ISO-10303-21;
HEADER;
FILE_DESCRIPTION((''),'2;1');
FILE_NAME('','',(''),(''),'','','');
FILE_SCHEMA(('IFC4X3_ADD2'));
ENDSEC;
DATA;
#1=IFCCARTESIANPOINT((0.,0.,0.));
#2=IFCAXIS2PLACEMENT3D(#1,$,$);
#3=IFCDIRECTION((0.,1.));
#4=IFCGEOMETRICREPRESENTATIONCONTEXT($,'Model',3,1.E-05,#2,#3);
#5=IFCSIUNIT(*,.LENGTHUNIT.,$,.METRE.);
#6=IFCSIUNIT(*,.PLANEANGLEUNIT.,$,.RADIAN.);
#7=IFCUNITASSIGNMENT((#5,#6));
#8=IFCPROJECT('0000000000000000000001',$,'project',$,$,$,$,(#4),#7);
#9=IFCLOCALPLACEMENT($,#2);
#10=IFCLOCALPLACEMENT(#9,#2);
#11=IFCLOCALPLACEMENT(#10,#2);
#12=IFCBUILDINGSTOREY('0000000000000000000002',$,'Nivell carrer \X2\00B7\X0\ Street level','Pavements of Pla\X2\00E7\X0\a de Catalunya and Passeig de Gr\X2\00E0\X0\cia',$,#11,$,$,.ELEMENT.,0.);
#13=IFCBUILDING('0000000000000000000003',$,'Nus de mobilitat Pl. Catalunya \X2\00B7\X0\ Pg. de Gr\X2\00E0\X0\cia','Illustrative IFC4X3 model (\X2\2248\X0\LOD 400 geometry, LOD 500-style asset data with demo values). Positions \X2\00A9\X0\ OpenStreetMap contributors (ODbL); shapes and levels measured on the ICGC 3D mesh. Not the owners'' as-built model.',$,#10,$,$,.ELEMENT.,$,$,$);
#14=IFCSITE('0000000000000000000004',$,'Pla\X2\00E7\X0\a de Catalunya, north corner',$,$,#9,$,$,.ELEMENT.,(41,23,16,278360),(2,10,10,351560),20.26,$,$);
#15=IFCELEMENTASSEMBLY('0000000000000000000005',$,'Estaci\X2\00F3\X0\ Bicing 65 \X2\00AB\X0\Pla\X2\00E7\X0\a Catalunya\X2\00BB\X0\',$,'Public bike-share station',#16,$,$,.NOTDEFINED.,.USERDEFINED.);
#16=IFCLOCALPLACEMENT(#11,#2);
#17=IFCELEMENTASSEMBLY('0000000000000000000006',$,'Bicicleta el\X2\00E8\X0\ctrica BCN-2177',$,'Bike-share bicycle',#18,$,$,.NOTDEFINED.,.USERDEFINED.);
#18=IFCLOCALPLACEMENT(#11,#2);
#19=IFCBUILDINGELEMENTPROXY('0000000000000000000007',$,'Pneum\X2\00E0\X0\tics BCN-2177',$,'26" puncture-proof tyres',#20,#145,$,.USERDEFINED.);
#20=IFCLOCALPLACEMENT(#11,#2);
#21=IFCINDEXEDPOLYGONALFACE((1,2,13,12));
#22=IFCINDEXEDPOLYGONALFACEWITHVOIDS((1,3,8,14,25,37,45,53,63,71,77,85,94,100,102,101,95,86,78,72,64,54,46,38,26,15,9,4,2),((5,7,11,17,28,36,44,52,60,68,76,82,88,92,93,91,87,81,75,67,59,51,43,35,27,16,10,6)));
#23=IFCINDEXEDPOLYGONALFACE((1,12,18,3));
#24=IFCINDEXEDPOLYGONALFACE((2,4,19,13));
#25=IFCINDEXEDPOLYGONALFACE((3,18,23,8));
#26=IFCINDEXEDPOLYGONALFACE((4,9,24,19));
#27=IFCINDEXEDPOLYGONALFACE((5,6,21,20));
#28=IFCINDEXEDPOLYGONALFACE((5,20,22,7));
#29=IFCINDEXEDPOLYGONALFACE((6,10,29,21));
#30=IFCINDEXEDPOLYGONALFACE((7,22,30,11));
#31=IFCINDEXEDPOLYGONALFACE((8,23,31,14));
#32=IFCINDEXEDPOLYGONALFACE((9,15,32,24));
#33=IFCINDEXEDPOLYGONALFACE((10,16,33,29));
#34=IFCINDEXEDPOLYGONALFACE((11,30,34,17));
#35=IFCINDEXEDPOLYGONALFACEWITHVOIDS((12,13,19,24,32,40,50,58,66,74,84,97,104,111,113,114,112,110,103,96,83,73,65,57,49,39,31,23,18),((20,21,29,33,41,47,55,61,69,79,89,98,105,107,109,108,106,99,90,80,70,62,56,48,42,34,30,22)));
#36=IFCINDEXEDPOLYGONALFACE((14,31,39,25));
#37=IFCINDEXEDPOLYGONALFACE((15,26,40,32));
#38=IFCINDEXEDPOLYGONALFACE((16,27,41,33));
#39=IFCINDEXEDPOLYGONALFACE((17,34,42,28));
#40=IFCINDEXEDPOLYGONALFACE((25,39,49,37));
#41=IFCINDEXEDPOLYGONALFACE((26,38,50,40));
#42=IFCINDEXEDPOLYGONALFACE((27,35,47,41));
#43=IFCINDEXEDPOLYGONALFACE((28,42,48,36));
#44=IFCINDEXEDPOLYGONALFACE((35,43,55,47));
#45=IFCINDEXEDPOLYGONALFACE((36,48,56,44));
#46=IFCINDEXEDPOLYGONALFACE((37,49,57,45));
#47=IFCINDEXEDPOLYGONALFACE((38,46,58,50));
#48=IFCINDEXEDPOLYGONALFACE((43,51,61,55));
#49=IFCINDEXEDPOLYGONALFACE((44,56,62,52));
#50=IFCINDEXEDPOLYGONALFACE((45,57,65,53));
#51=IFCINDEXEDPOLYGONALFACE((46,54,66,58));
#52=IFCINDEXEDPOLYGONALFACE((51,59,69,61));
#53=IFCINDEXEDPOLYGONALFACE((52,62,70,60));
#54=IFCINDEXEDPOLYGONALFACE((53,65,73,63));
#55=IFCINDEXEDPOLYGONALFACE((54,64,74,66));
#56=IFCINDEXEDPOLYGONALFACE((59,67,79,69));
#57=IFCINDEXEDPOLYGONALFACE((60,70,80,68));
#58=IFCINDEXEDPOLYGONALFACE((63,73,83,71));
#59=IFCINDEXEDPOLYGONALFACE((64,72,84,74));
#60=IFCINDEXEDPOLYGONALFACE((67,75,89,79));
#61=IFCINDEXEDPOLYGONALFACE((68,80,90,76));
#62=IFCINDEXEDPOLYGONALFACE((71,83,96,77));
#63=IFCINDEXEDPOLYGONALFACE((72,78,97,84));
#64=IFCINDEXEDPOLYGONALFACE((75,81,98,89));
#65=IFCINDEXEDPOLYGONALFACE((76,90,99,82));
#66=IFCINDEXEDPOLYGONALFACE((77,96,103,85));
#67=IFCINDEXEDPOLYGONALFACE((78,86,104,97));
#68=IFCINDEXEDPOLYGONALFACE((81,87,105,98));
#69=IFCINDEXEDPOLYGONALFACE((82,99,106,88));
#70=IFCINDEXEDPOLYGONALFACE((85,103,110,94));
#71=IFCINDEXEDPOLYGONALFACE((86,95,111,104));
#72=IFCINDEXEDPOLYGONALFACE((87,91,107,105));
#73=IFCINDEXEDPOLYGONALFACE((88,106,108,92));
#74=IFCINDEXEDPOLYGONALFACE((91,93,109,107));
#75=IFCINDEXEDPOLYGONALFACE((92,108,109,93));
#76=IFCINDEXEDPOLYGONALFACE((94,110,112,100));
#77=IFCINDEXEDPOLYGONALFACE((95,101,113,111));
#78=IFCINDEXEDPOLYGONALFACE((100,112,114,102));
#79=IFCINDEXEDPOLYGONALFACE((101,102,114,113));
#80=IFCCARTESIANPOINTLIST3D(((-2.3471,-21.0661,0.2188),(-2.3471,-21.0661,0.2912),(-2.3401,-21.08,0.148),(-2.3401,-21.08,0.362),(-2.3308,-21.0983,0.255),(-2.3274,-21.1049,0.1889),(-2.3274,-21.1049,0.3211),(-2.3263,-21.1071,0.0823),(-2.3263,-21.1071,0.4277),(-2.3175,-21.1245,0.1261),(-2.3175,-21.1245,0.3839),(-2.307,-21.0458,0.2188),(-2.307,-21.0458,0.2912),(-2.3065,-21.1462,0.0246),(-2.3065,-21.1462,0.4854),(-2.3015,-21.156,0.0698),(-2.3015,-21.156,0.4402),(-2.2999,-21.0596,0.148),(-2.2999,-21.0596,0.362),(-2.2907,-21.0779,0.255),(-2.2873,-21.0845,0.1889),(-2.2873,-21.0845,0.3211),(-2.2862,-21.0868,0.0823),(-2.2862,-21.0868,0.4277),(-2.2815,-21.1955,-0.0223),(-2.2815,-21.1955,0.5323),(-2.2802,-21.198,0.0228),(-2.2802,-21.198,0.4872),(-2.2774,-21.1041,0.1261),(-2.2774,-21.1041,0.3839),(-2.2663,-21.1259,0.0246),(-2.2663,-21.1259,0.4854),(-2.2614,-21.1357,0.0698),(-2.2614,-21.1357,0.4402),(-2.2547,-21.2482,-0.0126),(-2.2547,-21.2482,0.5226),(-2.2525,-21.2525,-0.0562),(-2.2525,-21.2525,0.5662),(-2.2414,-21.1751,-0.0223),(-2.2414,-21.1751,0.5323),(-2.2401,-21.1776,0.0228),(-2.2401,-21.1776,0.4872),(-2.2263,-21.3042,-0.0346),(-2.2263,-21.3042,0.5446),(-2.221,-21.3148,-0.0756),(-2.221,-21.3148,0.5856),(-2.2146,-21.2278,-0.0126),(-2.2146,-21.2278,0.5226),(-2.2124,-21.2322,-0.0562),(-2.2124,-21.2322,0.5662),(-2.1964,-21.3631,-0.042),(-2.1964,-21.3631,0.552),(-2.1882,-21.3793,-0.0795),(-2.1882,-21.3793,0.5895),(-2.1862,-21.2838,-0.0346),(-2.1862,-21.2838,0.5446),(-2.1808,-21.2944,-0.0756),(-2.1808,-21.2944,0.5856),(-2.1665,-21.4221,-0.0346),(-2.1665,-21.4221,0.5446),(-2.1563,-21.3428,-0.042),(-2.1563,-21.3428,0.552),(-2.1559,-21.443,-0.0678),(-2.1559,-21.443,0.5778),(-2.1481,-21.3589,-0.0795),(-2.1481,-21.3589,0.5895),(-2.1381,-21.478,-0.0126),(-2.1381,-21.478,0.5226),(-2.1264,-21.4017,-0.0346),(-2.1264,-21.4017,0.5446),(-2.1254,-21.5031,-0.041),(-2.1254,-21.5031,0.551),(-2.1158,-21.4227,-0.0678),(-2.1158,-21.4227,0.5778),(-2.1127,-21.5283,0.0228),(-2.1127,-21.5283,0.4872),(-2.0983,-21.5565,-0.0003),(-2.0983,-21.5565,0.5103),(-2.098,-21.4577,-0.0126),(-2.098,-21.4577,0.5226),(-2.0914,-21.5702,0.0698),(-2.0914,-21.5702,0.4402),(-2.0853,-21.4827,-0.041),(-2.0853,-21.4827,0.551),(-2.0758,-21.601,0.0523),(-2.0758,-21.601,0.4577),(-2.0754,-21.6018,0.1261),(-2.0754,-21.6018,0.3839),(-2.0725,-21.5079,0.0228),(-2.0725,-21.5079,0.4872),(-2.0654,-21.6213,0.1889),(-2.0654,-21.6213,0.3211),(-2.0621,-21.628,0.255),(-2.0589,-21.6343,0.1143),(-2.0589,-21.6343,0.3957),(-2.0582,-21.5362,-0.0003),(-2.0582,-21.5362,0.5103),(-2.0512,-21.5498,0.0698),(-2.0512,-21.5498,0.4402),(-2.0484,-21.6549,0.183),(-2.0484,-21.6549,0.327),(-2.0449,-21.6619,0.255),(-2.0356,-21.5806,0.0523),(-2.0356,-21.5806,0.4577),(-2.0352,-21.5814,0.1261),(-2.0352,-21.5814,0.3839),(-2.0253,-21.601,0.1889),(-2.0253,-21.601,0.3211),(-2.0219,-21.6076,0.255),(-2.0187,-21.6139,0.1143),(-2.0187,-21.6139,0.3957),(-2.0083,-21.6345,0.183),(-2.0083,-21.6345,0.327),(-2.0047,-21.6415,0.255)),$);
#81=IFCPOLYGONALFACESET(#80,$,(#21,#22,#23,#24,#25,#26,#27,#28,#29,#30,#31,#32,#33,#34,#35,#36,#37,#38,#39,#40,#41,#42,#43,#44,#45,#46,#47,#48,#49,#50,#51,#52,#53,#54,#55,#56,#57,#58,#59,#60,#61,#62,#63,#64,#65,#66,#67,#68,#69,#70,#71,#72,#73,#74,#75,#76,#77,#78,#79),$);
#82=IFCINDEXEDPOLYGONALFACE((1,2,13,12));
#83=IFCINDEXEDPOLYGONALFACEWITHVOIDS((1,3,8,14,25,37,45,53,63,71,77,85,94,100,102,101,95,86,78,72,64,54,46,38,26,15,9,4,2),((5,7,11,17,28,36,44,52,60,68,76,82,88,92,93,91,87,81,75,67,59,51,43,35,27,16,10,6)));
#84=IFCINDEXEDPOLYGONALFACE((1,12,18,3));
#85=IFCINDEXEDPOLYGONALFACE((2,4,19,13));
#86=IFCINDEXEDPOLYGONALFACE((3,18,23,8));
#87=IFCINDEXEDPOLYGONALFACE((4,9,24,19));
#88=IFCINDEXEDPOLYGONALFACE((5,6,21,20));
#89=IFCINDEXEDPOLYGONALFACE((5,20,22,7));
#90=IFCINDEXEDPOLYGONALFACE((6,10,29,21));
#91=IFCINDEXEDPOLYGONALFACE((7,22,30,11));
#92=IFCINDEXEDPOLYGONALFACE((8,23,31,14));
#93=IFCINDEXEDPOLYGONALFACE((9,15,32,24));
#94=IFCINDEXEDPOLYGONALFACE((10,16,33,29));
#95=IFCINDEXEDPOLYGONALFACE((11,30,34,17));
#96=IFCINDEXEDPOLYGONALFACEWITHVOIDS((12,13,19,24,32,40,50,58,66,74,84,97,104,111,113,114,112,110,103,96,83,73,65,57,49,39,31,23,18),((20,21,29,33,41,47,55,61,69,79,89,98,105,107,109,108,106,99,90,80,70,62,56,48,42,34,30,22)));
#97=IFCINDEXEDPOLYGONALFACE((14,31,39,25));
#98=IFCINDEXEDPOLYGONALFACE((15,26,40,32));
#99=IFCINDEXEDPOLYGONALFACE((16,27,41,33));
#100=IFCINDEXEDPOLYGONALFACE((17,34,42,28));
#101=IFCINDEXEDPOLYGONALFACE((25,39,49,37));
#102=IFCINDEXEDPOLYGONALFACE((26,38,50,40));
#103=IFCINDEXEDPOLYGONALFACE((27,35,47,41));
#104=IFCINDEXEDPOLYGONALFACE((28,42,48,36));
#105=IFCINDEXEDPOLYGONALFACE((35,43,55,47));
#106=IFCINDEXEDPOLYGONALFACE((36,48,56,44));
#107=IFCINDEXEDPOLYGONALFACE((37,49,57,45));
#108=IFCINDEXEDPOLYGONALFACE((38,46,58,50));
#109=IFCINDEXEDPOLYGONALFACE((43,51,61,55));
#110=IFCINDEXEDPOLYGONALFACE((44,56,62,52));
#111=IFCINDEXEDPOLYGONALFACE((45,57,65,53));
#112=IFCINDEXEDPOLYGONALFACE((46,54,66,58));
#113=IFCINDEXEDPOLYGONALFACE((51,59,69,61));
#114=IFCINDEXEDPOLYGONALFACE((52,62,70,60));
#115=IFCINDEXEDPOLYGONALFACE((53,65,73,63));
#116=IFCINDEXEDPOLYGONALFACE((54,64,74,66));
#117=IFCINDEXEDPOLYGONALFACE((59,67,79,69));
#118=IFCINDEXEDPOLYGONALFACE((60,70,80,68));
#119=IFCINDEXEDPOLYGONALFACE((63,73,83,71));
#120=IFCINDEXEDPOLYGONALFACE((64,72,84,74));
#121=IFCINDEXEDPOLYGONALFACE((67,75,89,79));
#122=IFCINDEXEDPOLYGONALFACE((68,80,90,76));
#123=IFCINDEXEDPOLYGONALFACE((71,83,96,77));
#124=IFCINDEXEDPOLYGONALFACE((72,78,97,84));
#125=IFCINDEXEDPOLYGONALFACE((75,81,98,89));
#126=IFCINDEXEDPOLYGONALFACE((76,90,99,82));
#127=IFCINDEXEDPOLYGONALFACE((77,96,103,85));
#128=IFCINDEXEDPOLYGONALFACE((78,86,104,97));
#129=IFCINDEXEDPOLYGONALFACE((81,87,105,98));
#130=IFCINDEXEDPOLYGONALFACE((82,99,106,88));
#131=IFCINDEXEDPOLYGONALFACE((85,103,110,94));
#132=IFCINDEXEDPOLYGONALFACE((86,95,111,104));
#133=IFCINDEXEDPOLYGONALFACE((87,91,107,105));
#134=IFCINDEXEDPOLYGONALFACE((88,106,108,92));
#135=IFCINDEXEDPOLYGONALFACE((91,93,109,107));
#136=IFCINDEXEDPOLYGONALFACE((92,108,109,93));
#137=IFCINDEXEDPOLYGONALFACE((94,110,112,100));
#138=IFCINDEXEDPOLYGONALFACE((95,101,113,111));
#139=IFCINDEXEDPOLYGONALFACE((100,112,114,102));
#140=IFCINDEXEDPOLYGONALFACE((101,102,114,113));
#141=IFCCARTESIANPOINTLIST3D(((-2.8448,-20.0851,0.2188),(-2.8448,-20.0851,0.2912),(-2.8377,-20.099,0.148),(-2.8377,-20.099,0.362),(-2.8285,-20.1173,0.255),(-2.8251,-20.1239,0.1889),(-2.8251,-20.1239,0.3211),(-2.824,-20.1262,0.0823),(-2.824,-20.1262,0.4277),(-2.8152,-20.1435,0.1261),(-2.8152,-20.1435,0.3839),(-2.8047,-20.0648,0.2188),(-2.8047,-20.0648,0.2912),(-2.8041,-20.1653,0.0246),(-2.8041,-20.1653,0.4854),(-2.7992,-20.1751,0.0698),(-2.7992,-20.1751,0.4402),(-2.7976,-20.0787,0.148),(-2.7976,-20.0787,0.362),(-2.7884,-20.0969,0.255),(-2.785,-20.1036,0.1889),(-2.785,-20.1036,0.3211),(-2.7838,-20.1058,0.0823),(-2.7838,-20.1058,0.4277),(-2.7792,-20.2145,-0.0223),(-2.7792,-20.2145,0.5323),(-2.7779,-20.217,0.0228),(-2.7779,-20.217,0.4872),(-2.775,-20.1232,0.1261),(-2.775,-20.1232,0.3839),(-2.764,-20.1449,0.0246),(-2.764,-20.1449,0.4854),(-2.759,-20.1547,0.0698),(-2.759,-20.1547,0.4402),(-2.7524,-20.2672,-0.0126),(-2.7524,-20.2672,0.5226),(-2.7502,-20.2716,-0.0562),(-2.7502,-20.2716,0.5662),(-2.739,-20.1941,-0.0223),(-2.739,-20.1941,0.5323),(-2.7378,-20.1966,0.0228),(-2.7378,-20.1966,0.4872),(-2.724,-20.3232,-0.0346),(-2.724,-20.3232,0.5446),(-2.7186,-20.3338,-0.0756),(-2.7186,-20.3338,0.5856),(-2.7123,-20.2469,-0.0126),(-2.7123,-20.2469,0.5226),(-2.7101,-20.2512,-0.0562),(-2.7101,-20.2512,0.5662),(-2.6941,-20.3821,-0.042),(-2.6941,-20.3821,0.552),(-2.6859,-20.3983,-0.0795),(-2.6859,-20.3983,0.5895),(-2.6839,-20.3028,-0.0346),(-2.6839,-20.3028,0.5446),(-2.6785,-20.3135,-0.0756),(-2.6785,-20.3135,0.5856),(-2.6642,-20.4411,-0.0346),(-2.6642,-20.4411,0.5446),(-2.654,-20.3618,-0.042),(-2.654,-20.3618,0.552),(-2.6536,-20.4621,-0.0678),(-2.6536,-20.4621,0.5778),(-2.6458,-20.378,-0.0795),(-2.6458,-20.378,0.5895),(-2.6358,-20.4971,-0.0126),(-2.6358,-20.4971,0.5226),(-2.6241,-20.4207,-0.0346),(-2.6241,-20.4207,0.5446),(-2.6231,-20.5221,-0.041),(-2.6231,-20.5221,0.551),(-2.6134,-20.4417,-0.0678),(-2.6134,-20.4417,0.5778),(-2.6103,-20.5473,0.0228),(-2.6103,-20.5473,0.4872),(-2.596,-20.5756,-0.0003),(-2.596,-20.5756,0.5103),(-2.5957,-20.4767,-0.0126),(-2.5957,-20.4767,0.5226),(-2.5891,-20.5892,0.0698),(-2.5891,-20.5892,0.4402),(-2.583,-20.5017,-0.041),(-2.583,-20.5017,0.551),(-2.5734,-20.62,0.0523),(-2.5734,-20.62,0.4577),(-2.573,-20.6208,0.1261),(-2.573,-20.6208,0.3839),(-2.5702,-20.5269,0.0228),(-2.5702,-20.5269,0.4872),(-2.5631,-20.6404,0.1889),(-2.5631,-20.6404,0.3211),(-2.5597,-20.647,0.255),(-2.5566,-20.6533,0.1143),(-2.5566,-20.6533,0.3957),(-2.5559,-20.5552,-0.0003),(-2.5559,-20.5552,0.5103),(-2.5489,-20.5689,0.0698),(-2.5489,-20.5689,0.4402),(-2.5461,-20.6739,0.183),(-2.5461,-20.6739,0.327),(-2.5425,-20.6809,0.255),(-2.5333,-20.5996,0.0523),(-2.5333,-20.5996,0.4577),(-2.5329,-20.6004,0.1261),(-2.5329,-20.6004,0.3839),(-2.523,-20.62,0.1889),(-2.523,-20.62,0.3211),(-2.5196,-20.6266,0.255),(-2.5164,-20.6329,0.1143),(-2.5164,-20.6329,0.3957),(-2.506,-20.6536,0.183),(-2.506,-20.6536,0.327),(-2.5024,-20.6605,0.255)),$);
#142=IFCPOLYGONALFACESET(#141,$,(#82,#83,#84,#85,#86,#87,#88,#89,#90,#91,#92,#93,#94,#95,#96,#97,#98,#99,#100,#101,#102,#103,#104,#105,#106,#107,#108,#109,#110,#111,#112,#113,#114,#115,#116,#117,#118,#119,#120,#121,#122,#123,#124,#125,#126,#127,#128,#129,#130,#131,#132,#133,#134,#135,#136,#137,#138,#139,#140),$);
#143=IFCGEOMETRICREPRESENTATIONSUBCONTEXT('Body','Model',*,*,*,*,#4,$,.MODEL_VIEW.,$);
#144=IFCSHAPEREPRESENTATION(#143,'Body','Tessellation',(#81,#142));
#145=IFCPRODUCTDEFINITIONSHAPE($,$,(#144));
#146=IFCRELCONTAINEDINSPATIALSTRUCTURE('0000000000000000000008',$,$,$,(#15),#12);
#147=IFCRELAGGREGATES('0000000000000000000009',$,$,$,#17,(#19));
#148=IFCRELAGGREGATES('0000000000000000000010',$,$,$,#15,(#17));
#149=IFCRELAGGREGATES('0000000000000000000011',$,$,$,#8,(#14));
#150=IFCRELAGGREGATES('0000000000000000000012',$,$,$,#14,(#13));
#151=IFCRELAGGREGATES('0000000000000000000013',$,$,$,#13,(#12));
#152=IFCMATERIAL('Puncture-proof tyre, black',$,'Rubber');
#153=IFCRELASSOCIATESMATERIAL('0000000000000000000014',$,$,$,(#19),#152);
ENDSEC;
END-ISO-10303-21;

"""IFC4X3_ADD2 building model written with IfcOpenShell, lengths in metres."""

from ifc_helpers import new_model, si_unit, direction, frame, origin, origin_2d_with_axis, place, context, subcontext, project, spatial, hollow_circle, extrude, material, element, aggregate, save


model = new_model("IFC4X3_ADD2")

# Units and contexts
model_context = context("Model", 3, precision=1e-05, world=origin(), true_north=direction((0.0, 1.0)))
body_context = subcontext(model_context, "Body", "Model", "MODEL_VIEW")
ifc_project = project(units=[si_unit("LENGTHUNIT", "METRE"), si_unit("PLANEANGLEUNIT", "RADIAN")], contexts=[model_context])

# Site, building, storey
site_placement = place(None, origin())
site = spatial("IfcSite", under=ifc_project, at=site_placement, Name="Plaça de Catalunya, north corner", CompositionType="ELEMENT", RefLatitude=(41, 23, 16, 278360), RefLongitude=(2, 10, 10, 351560), RefElevation=20.26)
building_placement = place(site_placement, origin())
building = spatial("IfcBuilding", under=site, at=building_placement, Name="Nus de mobilitat Pl. Catalunya · Pg. de Gràcia", Description="Illustrative IFC4X3 model (≈LOD 400 geometry, LOD 500-style asset data with demo values). Positions © OpenStreetMap contributors (ODbL); shapes and levels measured on the ICGC 3D mesh. Not the owners' as-built model.", CompositionType="ELEMENT")
storey_placement = place(building_placement, origin())
storey = spatial("IfcBuildingStorey", under=building, at=storey_placement, Name="Nivell carrer · Street level", Description="Pavements of Plaça de Catalunya and Passeig de Gràcia", CompositionType="ELEMENT", Elevation=0.0)

# Element assemblies, building element proxy
assembly_1_placement = place(building_placement, origin())
assembly_1 = element("IfcElementAssembly", 1, at=assembly_1_placement, inside=storey, Name="Estació Bicing 65 «Plaça Catalunya»", ObjectType="Public bike-share station", AssemblyPlace="NOTDEFINED", PredefinedType="USERDEFINED")
assembly_2_placement = place(building_placement, origin())
assembly_2 = element("IfcElementAssembly", 2, at=assembly_2_placement, Name="Bicicleta elèctrica BCN-2177", ObjectType="Bike-share bicycle", AssemblyPlace="NOTDEFINED", PredefinedType="USERDEFINED")
ifc_material_1 = material(Name="Puncture-proof tyre, black", Category="Rubber")
proxy_1_placement = place(building_placement, origin())
proxy_1 = element("IfcBuildingElementProxy", 3, at=proxy_1_placement, material=ifc_material_1, Name="Pneumàtics BCN-2177", ObjectType="26\" puncture-proof tyres", PredefinedType="USERDEFINED", context=body_context, shape_type="SweptSolid", body=[
    extrude(hollow_circle(Radius=0.335, WallThickness=0.038, at=origin_2d_with_axis()), frame((-2.1964, -21.3631, 0.255), z_axis=(0.891798, 0.452435, 0.0), x_axis=(0.452435, -0.891798, 0.0)), (0.0, 0.0, 1.0), 0.045),
    extrude(hollow_circle(Radius=0.335, WallThickness=0.038, at=origin_2d_with_axis()), frame((-2.6941, -20.3821, 0.255), z_axis=(0.891798, 0.452435, 0.0), x_axis=(0.452435, -0.891798, 0.0)), (0.0, 0.0, 1.0), 0.045),
])
aggregate(assembly_2, [proxy_1])
aggregate(assembly_1, [assembly_2])

save(model, "model.ifc")
